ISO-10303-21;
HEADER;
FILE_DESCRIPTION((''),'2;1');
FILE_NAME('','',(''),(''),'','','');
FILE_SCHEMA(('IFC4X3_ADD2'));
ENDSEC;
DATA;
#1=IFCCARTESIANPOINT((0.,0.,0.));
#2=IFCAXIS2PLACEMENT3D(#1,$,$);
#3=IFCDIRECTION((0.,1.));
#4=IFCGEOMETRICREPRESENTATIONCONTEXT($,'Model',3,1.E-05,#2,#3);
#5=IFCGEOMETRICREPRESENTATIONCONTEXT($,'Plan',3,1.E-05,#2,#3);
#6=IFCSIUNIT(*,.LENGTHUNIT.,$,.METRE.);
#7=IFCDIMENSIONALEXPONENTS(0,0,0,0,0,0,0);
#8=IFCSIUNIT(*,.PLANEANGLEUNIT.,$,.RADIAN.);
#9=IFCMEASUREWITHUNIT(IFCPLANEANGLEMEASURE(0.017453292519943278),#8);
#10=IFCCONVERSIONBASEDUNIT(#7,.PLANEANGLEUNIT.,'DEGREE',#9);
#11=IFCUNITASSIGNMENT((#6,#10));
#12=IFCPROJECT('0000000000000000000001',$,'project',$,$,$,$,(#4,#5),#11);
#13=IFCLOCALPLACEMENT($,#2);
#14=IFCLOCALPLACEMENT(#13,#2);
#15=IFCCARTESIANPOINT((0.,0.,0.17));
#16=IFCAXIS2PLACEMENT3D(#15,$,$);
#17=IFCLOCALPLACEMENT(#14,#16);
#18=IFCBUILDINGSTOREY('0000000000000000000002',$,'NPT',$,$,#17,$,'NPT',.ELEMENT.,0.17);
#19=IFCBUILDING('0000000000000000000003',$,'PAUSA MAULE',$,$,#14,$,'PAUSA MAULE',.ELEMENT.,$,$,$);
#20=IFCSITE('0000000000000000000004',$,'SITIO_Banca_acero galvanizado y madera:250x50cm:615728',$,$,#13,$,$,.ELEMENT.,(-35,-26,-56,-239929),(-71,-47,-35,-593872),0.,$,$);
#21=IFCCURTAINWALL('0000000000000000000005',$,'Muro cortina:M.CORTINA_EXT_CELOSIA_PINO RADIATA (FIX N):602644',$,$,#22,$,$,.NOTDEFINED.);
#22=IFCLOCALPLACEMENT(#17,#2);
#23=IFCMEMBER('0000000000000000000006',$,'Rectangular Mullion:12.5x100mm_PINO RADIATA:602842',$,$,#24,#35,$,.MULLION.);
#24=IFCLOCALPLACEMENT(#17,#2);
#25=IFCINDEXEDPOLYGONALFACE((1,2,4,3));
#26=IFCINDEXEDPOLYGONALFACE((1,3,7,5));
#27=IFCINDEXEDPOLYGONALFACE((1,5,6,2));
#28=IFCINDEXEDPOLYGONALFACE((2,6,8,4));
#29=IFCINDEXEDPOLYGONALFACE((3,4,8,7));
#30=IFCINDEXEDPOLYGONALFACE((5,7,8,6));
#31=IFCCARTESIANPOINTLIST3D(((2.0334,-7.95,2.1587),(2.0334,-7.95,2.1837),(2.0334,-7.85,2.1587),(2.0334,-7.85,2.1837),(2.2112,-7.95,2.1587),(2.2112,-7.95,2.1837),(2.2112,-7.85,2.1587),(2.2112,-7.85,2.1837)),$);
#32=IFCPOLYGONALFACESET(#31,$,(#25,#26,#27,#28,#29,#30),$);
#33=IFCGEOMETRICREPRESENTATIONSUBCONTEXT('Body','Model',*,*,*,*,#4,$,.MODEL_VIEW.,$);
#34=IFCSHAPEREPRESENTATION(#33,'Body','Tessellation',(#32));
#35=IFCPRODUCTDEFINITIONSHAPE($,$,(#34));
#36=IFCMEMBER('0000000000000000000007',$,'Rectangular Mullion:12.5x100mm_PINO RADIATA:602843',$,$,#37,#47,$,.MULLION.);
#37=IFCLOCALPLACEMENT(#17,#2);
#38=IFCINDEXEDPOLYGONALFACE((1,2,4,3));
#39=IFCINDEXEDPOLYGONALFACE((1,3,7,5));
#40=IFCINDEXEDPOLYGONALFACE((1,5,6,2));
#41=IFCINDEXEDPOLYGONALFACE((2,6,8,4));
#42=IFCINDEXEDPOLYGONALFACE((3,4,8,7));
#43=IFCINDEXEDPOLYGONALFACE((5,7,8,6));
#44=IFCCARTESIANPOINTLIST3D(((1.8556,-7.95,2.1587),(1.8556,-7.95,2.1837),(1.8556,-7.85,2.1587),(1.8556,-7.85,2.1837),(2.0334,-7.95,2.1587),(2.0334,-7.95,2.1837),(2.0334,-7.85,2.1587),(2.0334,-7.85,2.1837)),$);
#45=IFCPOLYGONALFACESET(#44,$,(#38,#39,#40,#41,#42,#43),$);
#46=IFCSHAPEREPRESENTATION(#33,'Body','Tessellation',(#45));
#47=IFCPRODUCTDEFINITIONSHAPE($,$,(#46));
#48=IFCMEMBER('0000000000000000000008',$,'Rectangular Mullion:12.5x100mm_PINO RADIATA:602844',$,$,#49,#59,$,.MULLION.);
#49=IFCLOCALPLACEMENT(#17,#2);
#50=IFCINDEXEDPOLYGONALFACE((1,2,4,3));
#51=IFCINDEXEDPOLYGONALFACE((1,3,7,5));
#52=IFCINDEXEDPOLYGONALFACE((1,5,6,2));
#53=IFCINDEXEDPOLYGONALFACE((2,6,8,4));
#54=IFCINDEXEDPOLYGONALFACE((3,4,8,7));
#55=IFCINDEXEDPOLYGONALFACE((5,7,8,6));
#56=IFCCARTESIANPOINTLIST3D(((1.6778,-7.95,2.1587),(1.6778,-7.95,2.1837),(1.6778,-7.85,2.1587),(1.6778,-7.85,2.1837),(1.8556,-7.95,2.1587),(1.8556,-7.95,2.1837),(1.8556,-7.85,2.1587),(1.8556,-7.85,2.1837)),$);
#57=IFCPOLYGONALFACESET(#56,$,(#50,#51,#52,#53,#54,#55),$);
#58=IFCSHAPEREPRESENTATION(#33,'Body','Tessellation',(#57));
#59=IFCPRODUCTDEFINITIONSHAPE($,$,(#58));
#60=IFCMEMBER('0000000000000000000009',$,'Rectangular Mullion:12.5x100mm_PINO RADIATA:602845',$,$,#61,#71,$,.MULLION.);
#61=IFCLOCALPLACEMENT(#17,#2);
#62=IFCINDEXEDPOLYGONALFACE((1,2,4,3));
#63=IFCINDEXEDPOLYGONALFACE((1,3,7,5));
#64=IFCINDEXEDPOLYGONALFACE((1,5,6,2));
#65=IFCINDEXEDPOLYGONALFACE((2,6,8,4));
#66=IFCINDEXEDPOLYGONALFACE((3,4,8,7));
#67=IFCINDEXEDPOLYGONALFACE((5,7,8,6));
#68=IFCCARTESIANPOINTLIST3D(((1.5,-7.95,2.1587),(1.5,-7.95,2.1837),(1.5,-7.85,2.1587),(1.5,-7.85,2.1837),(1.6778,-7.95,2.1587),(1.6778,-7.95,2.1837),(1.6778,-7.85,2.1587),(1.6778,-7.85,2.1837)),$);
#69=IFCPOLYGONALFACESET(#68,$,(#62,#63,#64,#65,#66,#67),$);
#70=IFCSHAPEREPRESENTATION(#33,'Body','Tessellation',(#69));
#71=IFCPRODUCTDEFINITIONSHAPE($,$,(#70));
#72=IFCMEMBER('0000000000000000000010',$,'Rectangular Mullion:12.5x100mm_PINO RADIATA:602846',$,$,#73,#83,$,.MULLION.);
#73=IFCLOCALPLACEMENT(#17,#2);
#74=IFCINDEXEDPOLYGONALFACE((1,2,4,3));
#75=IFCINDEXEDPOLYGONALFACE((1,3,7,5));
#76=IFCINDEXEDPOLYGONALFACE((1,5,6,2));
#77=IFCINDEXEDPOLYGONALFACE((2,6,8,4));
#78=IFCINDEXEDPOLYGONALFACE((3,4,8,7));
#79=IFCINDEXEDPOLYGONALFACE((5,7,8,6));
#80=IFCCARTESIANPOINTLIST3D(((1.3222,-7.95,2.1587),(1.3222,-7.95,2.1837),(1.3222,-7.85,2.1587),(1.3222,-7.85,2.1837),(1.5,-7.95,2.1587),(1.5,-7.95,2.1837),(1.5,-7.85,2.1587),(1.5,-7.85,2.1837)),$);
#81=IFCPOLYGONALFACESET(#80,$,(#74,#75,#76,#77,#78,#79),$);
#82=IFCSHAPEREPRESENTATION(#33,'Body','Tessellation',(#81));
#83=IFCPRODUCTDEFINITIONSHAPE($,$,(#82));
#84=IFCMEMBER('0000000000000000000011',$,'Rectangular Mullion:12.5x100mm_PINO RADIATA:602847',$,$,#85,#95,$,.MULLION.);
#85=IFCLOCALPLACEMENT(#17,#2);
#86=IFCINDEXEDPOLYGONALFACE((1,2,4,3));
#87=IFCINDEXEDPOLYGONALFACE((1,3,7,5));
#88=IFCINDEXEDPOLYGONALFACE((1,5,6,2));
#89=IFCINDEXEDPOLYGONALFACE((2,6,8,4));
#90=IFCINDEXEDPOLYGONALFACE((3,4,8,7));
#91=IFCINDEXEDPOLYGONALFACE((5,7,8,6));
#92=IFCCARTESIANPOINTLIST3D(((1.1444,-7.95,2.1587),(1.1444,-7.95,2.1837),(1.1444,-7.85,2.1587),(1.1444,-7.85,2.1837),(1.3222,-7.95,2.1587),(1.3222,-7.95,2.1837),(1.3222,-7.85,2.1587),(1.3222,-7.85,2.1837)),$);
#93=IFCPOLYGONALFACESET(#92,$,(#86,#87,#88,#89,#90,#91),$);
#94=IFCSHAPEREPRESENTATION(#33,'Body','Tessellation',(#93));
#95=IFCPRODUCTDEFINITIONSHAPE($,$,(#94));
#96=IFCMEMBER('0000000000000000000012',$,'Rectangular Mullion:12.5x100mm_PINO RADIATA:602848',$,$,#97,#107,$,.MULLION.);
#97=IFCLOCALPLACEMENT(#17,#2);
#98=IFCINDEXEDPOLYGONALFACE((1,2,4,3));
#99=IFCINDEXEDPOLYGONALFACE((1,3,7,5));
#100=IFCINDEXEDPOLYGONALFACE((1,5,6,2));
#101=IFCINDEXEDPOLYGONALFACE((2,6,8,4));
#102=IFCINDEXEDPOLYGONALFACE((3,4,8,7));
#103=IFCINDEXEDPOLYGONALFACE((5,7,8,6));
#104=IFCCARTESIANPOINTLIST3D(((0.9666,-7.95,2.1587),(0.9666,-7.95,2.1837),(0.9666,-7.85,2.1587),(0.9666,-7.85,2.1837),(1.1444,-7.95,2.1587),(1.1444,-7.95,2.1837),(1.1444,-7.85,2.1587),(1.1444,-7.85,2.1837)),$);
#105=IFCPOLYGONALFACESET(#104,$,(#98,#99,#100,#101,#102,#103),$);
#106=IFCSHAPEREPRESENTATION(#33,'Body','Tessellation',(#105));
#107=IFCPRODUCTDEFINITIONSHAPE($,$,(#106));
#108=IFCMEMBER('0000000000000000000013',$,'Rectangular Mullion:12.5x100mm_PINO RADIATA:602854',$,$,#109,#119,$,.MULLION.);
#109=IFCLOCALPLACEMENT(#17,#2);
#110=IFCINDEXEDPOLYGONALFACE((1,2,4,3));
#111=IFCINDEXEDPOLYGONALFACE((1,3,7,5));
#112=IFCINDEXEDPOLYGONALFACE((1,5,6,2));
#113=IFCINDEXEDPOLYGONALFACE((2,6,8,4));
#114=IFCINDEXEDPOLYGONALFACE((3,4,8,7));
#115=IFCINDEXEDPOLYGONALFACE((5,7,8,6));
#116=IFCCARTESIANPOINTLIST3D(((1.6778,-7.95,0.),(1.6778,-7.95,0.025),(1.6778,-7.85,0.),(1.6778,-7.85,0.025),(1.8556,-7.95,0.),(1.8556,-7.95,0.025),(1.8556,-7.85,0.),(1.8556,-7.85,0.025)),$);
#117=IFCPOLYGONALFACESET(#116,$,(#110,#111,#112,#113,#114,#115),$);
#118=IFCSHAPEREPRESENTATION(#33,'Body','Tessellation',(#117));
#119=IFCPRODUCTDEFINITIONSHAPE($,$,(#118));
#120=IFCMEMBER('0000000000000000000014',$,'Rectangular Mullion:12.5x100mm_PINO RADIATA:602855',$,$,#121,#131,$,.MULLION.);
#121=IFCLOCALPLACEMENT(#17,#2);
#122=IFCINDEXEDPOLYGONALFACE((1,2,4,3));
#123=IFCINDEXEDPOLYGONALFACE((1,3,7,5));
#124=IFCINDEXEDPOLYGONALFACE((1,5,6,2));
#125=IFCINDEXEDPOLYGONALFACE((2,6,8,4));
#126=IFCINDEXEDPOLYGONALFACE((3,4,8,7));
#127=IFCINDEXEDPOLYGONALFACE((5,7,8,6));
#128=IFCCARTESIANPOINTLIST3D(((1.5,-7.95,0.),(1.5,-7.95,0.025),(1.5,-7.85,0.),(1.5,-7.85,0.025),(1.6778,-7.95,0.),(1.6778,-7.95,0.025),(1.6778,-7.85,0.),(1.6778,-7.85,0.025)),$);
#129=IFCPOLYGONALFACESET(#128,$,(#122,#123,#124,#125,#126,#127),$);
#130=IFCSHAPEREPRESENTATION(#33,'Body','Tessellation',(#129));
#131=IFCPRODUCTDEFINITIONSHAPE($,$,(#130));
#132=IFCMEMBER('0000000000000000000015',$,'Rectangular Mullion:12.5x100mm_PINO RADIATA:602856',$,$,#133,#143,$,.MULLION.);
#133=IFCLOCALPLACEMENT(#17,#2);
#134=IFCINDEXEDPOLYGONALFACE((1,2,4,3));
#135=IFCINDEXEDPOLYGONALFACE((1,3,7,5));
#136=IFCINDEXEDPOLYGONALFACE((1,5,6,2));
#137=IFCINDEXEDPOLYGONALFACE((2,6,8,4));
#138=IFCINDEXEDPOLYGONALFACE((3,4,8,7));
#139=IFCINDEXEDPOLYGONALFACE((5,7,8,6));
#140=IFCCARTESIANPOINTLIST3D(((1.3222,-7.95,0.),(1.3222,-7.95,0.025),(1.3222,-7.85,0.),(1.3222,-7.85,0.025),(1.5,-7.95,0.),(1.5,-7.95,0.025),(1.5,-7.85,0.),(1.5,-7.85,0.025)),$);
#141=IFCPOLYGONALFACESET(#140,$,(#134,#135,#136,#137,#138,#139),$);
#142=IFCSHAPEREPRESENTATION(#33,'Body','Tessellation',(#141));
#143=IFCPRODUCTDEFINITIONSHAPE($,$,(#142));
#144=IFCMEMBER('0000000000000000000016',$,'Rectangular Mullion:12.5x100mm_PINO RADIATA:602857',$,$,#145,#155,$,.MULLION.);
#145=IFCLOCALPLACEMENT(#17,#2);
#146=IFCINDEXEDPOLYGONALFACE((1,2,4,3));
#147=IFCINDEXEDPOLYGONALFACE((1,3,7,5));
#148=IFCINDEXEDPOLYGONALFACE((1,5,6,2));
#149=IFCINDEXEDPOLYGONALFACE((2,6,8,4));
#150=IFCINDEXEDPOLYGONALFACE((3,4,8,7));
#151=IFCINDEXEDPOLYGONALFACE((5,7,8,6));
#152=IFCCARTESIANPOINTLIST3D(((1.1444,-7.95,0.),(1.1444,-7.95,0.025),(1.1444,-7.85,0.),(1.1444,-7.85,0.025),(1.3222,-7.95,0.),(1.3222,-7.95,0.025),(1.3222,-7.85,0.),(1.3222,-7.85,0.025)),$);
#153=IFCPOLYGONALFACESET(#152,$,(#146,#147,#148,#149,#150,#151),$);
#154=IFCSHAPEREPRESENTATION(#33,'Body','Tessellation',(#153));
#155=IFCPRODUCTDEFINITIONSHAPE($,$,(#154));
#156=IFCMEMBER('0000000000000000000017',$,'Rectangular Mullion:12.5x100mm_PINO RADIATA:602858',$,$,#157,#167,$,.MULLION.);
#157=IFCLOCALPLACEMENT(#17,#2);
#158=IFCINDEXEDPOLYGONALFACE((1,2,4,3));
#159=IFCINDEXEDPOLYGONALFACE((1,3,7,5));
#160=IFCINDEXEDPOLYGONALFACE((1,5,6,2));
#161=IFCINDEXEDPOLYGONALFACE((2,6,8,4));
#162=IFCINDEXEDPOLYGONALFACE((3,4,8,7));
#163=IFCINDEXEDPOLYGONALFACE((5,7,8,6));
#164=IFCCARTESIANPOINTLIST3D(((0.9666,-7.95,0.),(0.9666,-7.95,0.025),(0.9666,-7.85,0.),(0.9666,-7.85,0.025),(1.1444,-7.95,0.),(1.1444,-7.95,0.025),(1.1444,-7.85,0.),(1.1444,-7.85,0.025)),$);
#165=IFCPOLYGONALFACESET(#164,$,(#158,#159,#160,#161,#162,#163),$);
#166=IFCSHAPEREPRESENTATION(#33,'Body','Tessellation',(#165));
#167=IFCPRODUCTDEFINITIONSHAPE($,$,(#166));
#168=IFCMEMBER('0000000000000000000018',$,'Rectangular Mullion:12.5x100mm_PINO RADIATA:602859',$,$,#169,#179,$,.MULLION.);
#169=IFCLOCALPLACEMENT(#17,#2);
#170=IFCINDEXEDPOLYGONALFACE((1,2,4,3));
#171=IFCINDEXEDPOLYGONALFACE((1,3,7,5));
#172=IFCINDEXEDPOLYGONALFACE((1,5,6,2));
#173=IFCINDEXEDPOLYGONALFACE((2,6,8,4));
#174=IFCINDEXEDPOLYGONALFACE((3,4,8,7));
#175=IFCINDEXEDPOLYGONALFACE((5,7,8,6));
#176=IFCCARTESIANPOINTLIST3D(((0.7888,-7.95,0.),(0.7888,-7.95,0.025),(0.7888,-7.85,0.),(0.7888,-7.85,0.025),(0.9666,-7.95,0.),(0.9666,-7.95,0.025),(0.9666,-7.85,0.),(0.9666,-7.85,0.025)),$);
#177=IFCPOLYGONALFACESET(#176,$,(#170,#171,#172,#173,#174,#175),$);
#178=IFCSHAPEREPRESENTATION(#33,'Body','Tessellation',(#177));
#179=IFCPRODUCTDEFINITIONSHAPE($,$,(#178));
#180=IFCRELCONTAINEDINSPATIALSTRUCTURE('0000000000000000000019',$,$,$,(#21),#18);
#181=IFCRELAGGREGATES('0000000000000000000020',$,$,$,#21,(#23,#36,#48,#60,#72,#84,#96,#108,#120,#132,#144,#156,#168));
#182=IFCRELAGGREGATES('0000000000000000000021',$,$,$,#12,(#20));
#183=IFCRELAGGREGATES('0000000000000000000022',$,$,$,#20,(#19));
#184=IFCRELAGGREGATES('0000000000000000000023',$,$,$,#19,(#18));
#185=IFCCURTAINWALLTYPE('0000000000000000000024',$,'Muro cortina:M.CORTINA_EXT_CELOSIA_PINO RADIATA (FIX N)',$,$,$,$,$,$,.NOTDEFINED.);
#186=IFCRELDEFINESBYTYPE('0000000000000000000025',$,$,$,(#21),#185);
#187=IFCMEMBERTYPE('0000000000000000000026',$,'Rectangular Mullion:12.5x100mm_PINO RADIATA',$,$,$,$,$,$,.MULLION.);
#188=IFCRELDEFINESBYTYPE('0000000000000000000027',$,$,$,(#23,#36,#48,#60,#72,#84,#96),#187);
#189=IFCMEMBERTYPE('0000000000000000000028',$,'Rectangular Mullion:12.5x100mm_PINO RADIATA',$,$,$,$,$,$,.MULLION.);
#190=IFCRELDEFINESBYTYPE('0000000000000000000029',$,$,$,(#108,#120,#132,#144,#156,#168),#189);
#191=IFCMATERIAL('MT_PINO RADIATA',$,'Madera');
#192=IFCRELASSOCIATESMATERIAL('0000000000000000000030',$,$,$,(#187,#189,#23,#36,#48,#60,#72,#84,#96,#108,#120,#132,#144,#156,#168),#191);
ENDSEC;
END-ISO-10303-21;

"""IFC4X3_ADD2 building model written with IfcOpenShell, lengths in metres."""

from ifc_helpers import new_model, entity, si_unit, converted_unit, direction, frame, frame_2d, origin, place, context, subcontext, project, spatial, rectangle, extrude, source, transform, mapped, material, material_profile, profile_set, profile_usage, type_object, type_shapes, element, aggregate, save


model = new_model("IFC4X3_ADD2")

# Units and contexts
model_context = context("Model", 3, precision=1e-05, world=origin(), true_north=direction((0.0, 1.0)))
plan_context = context("Plan", 3, precision=1e-05, world=origin(), true_north=direction((0.0, 1.0)))
body_context = subcontext(model_context, "Body", "Model", "MODEL_VIEW")
ifc_project = project(units=[si_unit("LENGTHUNIT", "METRE"), converted_unit("PLANEANGLEUNIT", "DEGREE", entity("IfcPlaneAngleMeasure", 0.017453292519943278), si_unit("PLANEANGLEUNIT", "RADIAN"), dimensions=[0, 0, 0, 0, 0, 0, 0])], contexts=[model_context, plan_context])

# Site, building, storey
site_placement = place(None, origin())
site = spatial("IfcSite", under=ifc_project, at=site_placement, Name="SITIO_Banca_acero galvanizado y madera:250x50cm:615728", CompositionType="ELEMENT", RefLatitude=(-35, -26, -56, -239929), RefLongitude=(-71, -47, -35, -593872), RefElevation=0.0)
building_placement = place(site_placement, origin())
building = spatial("IfcBuilding", under=site, at=building_placement, Name="PAUSA MAULE", LongName="PAUSA MAULE", CompositionType="ELEMENT")
storey_placement = place(building_placement, frame((0.0, 0.0, 0.17)))
storey = spatial("IfcBuildingStorey", under=building, at=storey_placement, Name="NPT", LongName="NPT", CompositionType="ELEMENT", Elevation=0.17)

# Curtain wall, members
curtain_wall_type = type_object("IfcCurtainWallType", Name="Muro cortina:M.CORTINA_EXT_CELOSIA_PINO RADIATA (FIX N)", PredefinedType="NOTDEFINED")
curtain_wall_placement = place(storey_placement, frame((0.0, 0.0, -0.17)))
curtain_wall = element("IfcCurtainWall", 1, at=curtain_wall_placement, inside=storey, type_object=curtain_wall_type, Name="Muro cortina:M.CORTINA_EXT_CELOSIA_PINO RADIATA (FIX N):602644", PredefinedType="NOTDEFINED")
ifc_material = material(Name="MT_PINO RADIATA", Category="Madera")
ifc_material_profile = material_profile(ifc_material, rectangle(XDim=0.025, YDim=0.1, at=frame_2d((0.0, 0.0), x_axis=(1.0, 0.0))), Name="12.5x100mm_PINO RADIATA")
ifc_profile_set = profile_set([ifc_material_profile], Name="12.5x100mm_PINO RADIATA")
ifc_profile_usage = profile_usage(ifc_profile_set)
member_type_1 = type_object("IfcMemberType", Name="Rectangular Mullion:12.5x100mm_PINO RADIATA", PredefinedType="MULLION", material=ifc_profile_set)
shared_shape_1 = source(origin(), body_context, "Body", "SweptSolid", [
    extrude(rectangle(XDim=0.025, YDim=0.1, at=frame_2d((0.0, 0.0), x_axis=(1.0, 0.0))), frame((-0.0125, 0.0, -0.1778), z_axis=(0.0, 0.0, 1.0), x_axis=(-1.0, 0.0, 0.0)), (0.0, 0.0, 1.0), 0.1778),
])
type_shapes(member_type_1, [shared_shape_1])
member_1_placement = place(curtain_wall_placement, frame((2.0334, -7.9, 2.3537), z_axis=(-1.0, 0.0, 0.0), x_axis=(0.0, 0.0, 1.0)))
member_1 = element("IfcMember", 2, at=member_1_placement, type_object=member_type_1, material=ifc_profile_usage, Name="Rectangular Mullion:12.5x100mm_PINO RADIATA:602842", PredefinedType="MULLION", context=body_context, shape_type="MappedRepresentation", body=[
    mapped(shared_shape_1, transform((0.0, 0.0, 0.0), scale=1.0)),
])
member_2_placement = place(curtain_wall_placement, frame((1.8556, -7.9, 2.3537), z_axis=(-1.0, 0.0, 0.0), x_axis=(0.0, 0.0, 1.0)))
member_2 = element("IfcMember", 3, at=member_2_placement, type_object=member_type_1, material=ifc_profile_usage, Name="Rectangular Mullion:12.5x100mm_PINO RADIATA:602843", PredefinedType="MULLION", context=body_context, shape_type="MappedRepresentation", body=[
    mapped(shared_shape_1, transform((0.0, 0.0, 0.0), scale=1.0)),
])
member_3_placement = place(curtain_wall_placement, frame((1.6778, -7.9, 2.3537), z_axis=(-1.0, 0.0, 0.0), x_axis=(0.0, 0.0, 1.0)))
member_3 = element("IfcMember", 4, at=member_3_placement, type_object=member_type_1, material=ifc_profile_usage, Name="Rectangular Mullion:12.5x100mm_PINO RADIATA:602844", PredefinedType="MULLION", context=body_context, shape_type="MappedRepresentation", body=[
    mapped(shared_shape_1, transform((0.0, 0.0, 0.0), scale=1.0)),
])
member_4_placement = place(curtain_wall_placement, frame((1.5, -7.9, 2.3537), z_axis=(-1.0, 0.0, 0.0), x_axis=(0.0, 0.0, 1.0)))
member_4 = element("IfcMember", 5, at=member_4_placement, type_object=member_type_1, material=ifc_profile_usage, Name="Rectangular Mullion:12.5x100mm_PINO RADIATA:602845", PredefinedType="MULLION", context=body_context, shape_type="MappedRepresentation", body=[
    mapped(shared_shape_1, transform((0.0, 0.0, 0.0), scale=1.0)),
])
member_5_placement = place(curtain_wall_placement, frame((1.3222, -7.9, 2.3537), z_axis=(-1.0, 0.0, 0.0), x_axis=(0.0, 0.0, 1.0)))
member_5 = element("IfcMember", 6, at=member_5_placement, type_object=member_type_1, material=ifc_profile_usage, Name="Rectangular Mullion:12.5x100mm_PINO RADIATA:602846", PredefinedType="MULLION", context=body_context, shape_type="MappedRepresentation", body=[
    mapped(shared_shape_1, transform((0.0, 0.0, 0.0), scale=1.0)),
])
member_6_placement = place(curtain_wall_placement, frame((1.1444, -7.9, 2.3537), z_axis=(-1.0, 0.0, 0.0), x_axis=(0.0, 0.0, 1.0)))
member_6 = element("IfcMember", 7, at=member_6_placement, type_object=member_type_1, material=ifc_profile_usage, Name="Rectangular Mullion:12.5x100mm_PINO RADIATA:602847", PredefinedType="MULLION", context=body_context, shape_type="MappedRepresentation", body=[
    mapped(shared_shape_1, transform((0.0, 0.0, 0.0), scale=1.0)),
])
member_7_placement = place(curtain_wall_placement, frame((0.9666, -7.9, 2.3537), z_axis=(-1.0, 0.0, 0.0), x_axis=(0.0, 0.0, 1.0)))
member_7 = element("IfcMember", 8, at=member_7_placement, type_object=member_type_1, material=ifc_profile_usage, Name="Rectangular Mullion:12.5x100mm_PINO RADIATA:602848", PredefinedType="MULLION", context=body_context, shape_type="MappedRepresentation", body=[
    mapped(shared_shape_1, transform((0.0, 0.0, 0.0), scale=1.0)),
])
member_type_2 = type_object("IfcMemberType", Name="Rectangular Mullion:12.5x100mm_PINO RADIATA", PredefinedType="MULLION", material=ifc_profile_set)
shared_shape_2 = source(origin(), body_context, "Body", "SweptSolid", [
    extrude(rectangle(XDim=0.025, YDim=0.1, at=frame_2d((0.0, 0.0), x_axis=(1.0, 0.0))), frame((-0.0125, 0.0, -0.1778), z_axis=(0.0, 0.0, 1.0), x_axis=(-1.0, 0.0, 0.0)), (0.0, 0.0, 1.0), 0.1778),
])
type_shapes(member_type_2, [shared_shape_2])
member_8_placement = place(curtain_wall_placement, frame((1.8556, -7.9, 0.17), z_axis=(1.0, 0.0, 0.0), x_axis=(0.0, 0.0, -1.0)))
member_8 = element("IfcMember", 9, at=member_8_placement, type_object=member_type_2, material=ifc_profile_usage, Name="Rectangular Mullion:12.5x100mm_PINO RADIATA:602854", PredefinedType="MULLION", context=body_context, shape_type="MappedRepresentation", body=[
    mapped(shared_shape_2, transform((0.0, 0.0, 0.0), scale=1.0)),
])
member_9_placement = place(curtain_wall_placement, frame((1.6778, -7.9, 0.17), z_axis=(1.0, 0.0, 0.0), x_axis=(0.0, 0.0, -1.0)))
member_9 = element("IfcMember", 10, at=member_9_placement, type_object=member_type_2, material=ifc_profile_usage, Name="Rectangular Mullion:12.5x100mm_PINO RADIATA:602855", PredefinedType="MULLION", context=body_context, shape_type="MappedRepresentation", body=[
    mapped(shared_shape_2, transform((0.0, 0.0, 0.0), scale=1.0)),
])
member_10_placement = place(curtain_wall_placement, frame((1.5, -7.9, 0.17), z_axis=(1.0, 0.0, 0.0), x_axis=(0.0, 0.0, -1.0)))
member_10 = element("IfcMember", 11, at=member_10_placement, type_object=member_type_2, material=ifc_profile_usage, Name="Rectangular Mullion:12.5x100mm_PINO RADIATA:602856", PredefinedType="MULLION", context=body_context, shape_type="MappedRepresentation", body=[
    mapped(shared_shape_2, transform((0.0, 0.0, 0.0), scale=1.0)),
])
member_11_placement = place(curtain_wall_placement, frame((1.3222, -7.9, 0.17), z_axis=(1.0, 0.0, 0.0), x_axis=(0.0, 0.0, -1.0)))
member_11 = element("IfcMember", 12, at=member_11_placement, type_object=member_type_2, material=ifc_profile_usage, Name="Rectangular Mullion:12.5x100mm_PINO RADIATA:602857", PredefinedType="MULLION", context=body_context, shape_type="MappedRepresentation", body=[
    mapped(shared_shape_2, transform((0.0, 0.0, 0.0), scale=1.0)),
])
member_12_placement = place(curtain_wall_placement, frame((1.1444, -7.9, 0.17), z_axis=(1.0, 0.0, 0.0), x_axis=(0.0, 0.0, -1.0)))
member_12 = element("IfcMember", 13, at=member_12_placement, type_object=member_type_2, material=ifc_profile_usage, Name="Rectangular Mullion:12.5x100mm_PINO RADIATA:602858", PredefinedType="MULLION", context=body_context, shape_type="MappedRepresentation", body=[
    mapped(shared_shape_2, transform((0.0, 0.0, 0.0), scale=1.0)),
])
member_13_placement = place(curtain_wall_placement, frame((0.9666, -7.9, 0.17), z_axis=(1.0, 0.0, 0.0), x_axis=(0.0, 0.0, -1.0)))
member_13 = element("IfcMember", 14, at=member_13_placement, type_object=member_type_2, material=ifc_profile_usage, Name="Rectangular Mullion:12.5x100mm_PINO RADIATA:602859", PredefinedType="MULLION", context=body_context, shape_type="MappedRepresentation", body=[
    mapped(shared_shape_2, transform((0.0, 0.0, 0.0), scale=1.0)),
])
aggregate(curtain_wall, [member_1, member_2, member_3, member_4, member_5, member_6, member_7, member_8, member_9, member_10, member_11, member_12, member_13])

save(model, "model.ifc")
